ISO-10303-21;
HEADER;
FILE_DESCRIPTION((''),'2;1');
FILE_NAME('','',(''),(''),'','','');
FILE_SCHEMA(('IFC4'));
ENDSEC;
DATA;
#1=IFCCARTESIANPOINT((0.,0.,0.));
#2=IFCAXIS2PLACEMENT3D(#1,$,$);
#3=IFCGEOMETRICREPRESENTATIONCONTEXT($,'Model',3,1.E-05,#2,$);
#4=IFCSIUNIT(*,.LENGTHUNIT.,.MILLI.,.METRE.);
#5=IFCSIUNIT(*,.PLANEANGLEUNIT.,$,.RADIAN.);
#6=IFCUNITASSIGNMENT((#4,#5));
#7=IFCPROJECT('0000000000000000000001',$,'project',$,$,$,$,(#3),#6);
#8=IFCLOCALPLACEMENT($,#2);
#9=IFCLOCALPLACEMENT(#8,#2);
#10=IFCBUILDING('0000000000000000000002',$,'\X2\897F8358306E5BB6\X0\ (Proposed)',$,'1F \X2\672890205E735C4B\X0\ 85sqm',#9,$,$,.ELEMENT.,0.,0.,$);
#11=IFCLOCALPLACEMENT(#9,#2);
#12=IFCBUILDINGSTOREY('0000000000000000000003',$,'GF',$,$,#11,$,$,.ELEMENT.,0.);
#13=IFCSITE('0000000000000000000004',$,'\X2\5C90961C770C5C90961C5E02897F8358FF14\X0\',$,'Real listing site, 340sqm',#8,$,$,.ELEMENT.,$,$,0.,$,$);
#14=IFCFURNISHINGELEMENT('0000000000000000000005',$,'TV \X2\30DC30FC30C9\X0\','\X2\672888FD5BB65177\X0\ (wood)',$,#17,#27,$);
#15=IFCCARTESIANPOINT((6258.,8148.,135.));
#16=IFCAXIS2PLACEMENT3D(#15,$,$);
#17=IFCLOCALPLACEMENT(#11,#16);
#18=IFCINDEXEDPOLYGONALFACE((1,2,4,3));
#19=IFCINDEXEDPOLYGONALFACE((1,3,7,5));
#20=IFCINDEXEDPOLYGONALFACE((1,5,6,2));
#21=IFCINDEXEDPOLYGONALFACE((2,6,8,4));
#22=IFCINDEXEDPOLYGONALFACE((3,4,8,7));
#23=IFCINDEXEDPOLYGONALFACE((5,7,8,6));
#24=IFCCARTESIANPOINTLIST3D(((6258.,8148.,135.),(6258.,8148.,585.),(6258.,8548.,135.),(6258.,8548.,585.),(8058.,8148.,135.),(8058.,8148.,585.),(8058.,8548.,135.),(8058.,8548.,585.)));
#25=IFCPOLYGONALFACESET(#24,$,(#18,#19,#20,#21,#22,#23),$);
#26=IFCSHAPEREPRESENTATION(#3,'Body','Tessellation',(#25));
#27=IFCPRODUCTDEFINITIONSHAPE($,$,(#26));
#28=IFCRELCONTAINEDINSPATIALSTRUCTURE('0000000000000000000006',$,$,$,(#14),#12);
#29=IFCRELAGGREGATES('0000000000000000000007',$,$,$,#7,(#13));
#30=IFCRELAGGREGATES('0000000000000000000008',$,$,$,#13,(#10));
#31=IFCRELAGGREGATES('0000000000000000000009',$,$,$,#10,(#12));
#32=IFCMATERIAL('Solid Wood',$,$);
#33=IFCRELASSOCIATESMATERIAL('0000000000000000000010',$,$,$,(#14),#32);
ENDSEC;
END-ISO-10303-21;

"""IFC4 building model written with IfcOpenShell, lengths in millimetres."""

from ifc_helpers import new_model, si_unit, frame, frame_2d, origin, place, context, project, spatial, rectangle, extrude, material, element, save


model = new_model("IFC4")

# Units and contexts
model_context = context("Model", 3, precision=1e-05, world=origin())
ifc_project = project(units=[si_unit("LENGTHUNIT", "METRE", prefix="MILLI"), si_unit("PLANEANGLEUNIT", "RADIAN")], contexts=[model_context])

# Site, building, storey
site_placement = place(None, origin())
site = spatial("IfcSite", under=ifc_project, at=site_placement, Name="岐阜県岐阜市西荘４", ObjectType="Real listing site, 340sqm", CompositionType="ELEMENT", RefElevation=0.0)
building_placement = place(site_placement, origin())
building = spatial("IfcBuilding", under=site, at=building_placement, Name="西荘の家 (Proposed)", ObjectType="1F 木造平屋 85sqm", CompositionType="ELEMENT", ElevationOfRefHeight=0.0, ElevationOfTerrain=0.0)
storey_placement = place(building_placement, origin())
storey = spatial("IfcBuildingStorey", under=building, at=storey_placement, Name="GF", CompositionType="ELEMENT", Elevation=0.0)

# Shared definitions
ifc_material_1 = material(Name="Solid Wood")

# Furnishing element
furnishing_1_placement = place(storey_placement, frame((6258.0, 8148.0, 135.0)))
element("IfcFurnishingElement", 1, at=furnishing_1_placement, inside=storey, material=ifc_material_1, Name="TV ボード", Description="木製家具 (wood)", context=model_context, shape_type="SweptSolid", body=[
    extrude(rectangle(XDim=1800.0, YDim=400.0, at=frame_2d((900.0, 200.0))), frame((6258.0, 8148.0, 135.0)), (0.0, 0.0, 1.0), 450.0),
])

save(model, "model.ifc")
